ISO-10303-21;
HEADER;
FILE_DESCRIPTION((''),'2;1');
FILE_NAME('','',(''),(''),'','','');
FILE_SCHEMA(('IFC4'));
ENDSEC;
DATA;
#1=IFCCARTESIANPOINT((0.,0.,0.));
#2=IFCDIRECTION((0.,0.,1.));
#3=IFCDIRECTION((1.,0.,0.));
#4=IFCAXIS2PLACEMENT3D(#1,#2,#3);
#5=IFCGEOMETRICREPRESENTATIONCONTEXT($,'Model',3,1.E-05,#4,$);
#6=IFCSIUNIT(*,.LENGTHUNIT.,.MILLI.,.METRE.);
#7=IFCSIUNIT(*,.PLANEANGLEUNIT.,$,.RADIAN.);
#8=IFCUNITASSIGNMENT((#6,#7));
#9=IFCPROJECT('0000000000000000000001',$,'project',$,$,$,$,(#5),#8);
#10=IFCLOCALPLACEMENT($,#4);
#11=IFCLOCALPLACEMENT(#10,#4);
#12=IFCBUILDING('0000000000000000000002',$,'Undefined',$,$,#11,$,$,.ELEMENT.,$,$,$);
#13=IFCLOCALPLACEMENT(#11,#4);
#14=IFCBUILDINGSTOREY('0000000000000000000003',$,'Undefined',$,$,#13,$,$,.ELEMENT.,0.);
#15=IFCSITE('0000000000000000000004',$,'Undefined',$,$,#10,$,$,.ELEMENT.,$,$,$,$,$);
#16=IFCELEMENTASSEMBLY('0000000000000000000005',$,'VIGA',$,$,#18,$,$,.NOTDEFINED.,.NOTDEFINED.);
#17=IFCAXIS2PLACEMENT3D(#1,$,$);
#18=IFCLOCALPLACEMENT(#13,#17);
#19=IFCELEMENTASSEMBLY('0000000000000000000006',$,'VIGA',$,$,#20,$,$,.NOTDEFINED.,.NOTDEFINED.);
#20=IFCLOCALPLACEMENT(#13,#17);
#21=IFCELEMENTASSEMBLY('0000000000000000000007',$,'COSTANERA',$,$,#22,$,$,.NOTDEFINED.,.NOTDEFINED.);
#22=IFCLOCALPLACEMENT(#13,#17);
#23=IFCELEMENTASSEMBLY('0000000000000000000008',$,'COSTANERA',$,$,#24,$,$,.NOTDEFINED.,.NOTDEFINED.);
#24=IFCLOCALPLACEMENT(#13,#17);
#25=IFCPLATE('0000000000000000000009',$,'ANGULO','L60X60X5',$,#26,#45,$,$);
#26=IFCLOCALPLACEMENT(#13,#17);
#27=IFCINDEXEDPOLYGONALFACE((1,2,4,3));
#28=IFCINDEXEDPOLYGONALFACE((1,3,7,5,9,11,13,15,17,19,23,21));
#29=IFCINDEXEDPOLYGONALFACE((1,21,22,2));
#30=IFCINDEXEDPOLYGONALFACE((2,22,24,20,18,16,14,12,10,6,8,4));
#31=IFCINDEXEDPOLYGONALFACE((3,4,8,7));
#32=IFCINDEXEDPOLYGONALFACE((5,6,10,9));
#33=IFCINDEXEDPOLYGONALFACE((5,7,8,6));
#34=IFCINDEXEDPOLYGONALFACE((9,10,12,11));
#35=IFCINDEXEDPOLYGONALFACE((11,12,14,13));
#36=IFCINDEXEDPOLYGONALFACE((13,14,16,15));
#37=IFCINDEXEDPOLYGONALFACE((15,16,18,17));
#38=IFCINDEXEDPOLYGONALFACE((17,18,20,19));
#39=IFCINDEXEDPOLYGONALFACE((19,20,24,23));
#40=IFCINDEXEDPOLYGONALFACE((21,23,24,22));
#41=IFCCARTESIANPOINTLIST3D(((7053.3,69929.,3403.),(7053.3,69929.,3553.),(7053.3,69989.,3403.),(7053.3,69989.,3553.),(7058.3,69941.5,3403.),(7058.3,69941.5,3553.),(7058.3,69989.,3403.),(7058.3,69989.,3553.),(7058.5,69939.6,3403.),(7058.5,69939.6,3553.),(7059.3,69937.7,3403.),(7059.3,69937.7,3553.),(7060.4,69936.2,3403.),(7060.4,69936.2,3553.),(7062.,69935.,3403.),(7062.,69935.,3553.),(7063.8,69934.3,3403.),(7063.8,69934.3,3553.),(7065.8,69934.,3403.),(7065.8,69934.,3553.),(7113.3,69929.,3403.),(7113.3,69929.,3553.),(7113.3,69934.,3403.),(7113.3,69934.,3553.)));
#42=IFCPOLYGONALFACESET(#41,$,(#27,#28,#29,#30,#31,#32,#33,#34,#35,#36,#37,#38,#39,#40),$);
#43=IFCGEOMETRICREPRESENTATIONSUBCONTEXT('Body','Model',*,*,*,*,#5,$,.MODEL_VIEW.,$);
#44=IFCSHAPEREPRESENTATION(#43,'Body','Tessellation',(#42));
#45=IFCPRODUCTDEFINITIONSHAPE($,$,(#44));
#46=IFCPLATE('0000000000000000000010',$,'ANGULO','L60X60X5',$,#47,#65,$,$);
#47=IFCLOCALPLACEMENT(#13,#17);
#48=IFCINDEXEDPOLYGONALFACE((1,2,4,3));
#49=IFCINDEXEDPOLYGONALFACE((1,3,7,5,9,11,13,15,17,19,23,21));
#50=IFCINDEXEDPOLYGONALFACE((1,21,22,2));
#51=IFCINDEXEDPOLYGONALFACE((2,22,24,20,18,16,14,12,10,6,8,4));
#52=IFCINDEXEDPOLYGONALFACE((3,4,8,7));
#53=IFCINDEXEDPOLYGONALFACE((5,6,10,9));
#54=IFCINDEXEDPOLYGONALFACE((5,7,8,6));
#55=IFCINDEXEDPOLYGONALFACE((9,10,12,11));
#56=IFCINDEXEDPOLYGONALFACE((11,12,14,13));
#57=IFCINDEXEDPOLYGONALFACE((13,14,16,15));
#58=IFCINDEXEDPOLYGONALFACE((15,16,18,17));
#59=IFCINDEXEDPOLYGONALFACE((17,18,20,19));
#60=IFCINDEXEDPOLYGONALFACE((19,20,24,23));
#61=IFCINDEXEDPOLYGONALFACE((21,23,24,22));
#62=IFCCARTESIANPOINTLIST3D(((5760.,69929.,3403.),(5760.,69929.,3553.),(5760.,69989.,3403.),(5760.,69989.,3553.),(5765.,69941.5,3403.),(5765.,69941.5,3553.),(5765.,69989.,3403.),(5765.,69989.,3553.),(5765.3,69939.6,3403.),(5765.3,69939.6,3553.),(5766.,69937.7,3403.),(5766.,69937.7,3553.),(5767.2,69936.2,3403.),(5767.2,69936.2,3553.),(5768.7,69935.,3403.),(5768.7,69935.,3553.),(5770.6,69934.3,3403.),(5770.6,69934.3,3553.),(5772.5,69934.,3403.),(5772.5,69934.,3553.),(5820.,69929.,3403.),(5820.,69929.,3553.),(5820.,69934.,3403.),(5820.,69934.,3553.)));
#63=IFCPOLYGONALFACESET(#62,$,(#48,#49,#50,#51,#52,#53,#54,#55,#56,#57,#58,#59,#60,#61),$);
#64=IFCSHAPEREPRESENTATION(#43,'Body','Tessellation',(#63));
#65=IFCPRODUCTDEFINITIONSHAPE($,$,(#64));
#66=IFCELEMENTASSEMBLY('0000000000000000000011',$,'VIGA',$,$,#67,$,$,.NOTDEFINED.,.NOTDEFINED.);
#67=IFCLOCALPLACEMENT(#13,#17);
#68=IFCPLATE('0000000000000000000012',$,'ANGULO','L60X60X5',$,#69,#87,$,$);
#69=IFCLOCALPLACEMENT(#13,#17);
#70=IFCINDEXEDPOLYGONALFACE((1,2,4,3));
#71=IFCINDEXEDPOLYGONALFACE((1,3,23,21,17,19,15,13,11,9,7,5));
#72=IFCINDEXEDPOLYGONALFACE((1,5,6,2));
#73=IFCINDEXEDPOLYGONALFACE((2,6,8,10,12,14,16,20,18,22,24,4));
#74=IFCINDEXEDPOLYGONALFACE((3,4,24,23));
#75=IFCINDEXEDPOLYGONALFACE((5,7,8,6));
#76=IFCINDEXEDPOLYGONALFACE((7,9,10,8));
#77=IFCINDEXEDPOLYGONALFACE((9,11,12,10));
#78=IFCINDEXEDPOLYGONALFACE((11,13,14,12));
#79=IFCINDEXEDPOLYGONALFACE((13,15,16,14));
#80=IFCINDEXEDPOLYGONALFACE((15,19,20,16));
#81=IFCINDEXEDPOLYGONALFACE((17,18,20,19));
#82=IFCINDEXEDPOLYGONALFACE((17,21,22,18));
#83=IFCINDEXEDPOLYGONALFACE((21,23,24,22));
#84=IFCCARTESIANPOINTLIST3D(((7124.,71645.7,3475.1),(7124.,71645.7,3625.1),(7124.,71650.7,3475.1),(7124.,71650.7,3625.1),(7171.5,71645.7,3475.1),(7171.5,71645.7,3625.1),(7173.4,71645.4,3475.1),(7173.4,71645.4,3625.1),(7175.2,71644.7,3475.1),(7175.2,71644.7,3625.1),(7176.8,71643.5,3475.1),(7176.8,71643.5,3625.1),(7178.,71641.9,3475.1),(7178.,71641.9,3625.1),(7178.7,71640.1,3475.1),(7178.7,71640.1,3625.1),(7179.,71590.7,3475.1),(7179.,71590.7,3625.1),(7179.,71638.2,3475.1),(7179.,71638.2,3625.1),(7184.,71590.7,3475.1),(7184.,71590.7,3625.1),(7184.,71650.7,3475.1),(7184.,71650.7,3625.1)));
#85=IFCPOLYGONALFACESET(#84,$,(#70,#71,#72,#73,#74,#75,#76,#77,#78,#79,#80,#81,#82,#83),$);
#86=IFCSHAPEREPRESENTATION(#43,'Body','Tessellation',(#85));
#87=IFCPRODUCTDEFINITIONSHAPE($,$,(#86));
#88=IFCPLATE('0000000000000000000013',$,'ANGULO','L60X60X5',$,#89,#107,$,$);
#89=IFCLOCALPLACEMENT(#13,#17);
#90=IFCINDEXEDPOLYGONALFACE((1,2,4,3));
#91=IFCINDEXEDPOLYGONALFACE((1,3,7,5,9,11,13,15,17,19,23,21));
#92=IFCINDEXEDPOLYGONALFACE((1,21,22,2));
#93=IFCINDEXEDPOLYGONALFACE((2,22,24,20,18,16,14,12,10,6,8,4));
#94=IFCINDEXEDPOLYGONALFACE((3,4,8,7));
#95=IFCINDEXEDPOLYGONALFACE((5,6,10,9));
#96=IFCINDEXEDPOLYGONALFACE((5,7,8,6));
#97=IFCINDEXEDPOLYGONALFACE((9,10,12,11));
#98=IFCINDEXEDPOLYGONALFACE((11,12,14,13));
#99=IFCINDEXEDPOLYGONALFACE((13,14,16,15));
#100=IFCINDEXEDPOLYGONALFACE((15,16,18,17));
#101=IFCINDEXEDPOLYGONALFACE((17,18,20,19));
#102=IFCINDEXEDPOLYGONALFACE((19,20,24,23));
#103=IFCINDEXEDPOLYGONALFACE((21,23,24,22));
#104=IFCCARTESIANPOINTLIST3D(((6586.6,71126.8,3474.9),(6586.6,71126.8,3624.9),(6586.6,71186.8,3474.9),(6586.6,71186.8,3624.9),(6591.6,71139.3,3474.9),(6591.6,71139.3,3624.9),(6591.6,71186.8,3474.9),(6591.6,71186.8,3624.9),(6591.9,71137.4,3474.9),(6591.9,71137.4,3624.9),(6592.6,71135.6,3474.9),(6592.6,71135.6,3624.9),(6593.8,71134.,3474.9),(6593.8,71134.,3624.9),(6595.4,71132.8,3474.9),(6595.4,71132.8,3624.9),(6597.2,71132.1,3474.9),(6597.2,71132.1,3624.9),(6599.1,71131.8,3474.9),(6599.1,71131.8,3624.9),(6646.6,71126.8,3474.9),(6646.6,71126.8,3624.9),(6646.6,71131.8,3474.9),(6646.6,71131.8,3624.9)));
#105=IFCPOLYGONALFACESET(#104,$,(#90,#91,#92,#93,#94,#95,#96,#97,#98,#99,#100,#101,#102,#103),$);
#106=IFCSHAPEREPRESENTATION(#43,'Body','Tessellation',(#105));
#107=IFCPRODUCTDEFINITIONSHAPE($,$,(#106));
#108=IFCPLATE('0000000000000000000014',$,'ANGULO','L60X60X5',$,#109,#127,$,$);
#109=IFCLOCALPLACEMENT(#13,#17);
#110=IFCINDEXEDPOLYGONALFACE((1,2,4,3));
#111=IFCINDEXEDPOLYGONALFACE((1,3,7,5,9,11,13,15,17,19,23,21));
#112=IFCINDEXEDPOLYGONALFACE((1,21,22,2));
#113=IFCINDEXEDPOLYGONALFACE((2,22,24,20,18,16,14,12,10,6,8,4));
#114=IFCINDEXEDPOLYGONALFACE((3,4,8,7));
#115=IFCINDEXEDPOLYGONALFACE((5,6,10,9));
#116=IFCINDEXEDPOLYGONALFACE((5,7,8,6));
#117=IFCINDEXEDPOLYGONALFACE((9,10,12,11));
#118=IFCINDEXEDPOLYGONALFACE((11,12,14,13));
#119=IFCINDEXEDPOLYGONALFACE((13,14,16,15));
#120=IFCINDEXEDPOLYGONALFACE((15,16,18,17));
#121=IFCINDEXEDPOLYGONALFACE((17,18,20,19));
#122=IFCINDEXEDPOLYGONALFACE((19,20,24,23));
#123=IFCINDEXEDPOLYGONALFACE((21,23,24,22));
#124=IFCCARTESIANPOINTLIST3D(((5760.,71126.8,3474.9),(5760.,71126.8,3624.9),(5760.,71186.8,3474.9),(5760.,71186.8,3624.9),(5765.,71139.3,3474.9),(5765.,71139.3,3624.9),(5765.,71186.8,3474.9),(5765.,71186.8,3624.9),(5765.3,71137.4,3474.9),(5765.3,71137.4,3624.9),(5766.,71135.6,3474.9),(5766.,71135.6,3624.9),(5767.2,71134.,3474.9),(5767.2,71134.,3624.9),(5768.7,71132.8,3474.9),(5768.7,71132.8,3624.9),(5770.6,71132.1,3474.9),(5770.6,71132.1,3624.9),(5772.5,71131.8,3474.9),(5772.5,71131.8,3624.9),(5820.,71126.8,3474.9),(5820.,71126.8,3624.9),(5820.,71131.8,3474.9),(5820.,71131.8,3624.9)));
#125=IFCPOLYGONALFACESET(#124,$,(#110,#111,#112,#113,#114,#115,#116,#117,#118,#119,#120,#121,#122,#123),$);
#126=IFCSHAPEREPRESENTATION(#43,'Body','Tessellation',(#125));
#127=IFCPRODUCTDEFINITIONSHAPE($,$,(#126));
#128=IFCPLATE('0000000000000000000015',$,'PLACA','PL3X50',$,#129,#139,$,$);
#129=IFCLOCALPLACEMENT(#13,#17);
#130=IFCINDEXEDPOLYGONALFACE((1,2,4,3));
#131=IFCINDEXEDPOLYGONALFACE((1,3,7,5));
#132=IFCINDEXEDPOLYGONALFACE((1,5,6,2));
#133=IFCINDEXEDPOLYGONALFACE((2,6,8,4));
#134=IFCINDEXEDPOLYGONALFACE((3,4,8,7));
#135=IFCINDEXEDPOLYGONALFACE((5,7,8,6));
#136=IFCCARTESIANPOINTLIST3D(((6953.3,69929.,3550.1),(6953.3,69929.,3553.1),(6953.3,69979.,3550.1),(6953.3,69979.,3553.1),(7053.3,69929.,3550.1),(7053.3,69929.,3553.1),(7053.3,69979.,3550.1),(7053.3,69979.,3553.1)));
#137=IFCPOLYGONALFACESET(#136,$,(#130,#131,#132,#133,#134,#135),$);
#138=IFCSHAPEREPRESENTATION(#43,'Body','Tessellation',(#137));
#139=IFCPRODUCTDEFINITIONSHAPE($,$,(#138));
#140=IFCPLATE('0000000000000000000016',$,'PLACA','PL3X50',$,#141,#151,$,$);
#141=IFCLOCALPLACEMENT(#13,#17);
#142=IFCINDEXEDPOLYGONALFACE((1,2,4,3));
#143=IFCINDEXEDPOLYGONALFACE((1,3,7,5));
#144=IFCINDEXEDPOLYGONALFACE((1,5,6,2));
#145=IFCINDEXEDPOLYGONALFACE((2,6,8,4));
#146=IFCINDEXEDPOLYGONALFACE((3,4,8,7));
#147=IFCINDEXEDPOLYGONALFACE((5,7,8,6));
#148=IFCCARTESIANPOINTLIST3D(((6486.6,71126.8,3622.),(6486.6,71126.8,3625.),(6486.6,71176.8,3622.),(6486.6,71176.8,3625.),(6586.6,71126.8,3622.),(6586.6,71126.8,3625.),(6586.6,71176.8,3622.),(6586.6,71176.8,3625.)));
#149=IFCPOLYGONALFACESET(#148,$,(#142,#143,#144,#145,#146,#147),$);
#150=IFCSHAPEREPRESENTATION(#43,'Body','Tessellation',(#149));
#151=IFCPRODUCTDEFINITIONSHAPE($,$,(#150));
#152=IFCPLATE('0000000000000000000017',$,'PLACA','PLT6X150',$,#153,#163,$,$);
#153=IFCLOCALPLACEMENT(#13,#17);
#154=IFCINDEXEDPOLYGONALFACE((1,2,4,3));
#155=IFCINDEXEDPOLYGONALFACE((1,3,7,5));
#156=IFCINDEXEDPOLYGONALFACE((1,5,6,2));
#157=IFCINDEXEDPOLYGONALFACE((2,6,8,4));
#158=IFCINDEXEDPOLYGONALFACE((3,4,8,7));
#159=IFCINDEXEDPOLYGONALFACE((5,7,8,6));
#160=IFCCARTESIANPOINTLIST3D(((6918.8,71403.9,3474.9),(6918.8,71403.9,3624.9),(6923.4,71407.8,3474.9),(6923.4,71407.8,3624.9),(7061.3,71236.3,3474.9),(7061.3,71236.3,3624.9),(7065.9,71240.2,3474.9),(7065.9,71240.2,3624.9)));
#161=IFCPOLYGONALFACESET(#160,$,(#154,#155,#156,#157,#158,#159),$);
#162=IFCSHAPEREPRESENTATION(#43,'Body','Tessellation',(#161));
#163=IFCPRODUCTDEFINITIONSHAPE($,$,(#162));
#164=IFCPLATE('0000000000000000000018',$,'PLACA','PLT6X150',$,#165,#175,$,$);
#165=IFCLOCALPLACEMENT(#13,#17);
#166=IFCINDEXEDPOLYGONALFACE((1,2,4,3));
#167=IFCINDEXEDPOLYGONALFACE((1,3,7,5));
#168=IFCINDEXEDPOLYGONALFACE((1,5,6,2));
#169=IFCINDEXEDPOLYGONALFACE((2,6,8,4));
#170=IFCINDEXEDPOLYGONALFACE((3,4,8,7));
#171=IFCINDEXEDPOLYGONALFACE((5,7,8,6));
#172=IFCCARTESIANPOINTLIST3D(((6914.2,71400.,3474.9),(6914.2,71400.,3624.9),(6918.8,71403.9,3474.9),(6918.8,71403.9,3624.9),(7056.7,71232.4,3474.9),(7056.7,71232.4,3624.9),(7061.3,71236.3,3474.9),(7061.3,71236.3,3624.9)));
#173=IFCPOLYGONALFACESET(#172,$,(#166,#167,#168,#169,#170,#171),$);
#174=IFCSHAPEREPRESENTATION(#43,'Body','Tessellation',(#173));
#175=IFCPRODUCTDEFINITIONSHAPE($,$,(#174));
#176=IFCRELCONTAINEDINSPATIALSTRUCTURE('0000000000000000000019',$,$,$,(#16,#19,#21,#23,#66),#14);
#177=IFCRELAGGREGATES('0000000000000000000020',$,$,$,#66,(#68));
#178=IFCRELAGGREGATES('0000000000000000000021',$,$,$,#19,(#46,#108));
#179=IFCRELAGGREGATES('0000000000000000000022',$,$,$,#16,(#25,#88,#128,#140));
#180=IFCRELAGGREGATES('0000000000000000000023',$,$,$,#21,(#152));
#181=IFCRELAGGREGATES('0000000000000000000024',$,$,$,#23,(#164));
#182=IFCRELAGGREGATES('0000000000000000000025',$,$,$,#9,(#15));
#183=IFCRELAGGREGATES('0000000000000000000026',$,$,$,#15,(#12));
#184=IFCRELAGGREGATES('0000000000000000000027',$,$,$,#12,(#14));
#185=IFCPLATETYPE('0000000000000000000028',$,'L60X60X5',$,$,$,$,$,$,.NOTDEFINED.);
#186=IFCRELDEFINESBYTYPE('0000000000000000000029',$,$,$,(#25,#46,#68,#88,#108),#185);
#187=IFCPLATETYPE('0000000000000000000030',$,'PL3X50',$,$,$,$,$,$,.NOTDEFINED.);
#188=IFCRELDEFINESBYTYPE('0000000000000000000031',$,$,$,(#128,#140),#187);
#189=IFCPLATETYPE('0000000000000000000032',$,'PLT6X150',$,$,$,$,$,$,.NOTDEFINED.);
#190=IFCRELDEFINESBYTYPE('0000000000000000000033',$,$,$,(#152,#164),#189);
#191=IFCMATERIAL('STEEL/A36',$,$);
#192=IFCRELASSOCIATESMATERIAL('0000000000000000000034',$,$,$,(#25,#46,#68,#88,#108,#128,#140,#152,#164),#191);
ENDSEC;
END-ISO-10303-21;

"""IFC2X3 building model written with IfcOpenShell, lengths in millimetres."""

from ifc_helpers import new_model, si_unit, frame, origin_with_axes, origin_2d_with_axis, place, context, subcontext, project, spatial, polyline, l_section, outline, extrude, material, type_object, element, aggregate, save


model = new_model("IFC2X3")

# Units and contexts
model_context = context("Model", 3, precision=1e-05, world=origin_with_axes())
body_context = subcontext(model_context, "Body", "Model", "MODEL_VIEW")
ifc_project = project(units=[si_unit("LENGTHUNIT", "METRE", prefix="MILLI"), si_unit("PLANEANGLEUNIT", "RADIAN")], contexts=[model_context])

# Site, building, storey
site_placement = place(None, origin_with_axes())
site = spatial("IfcSite", under=ifc_project, at=site_placement, Name="Undefined", CompositionType="ELEMENT")
building_placement = place(site_placement, origin_with_axes())
building = spatial("IfcBuilding", under=site, at=building_placement, Name="Undefined", CompositionType="ELEMENT")
storey_placement = place(building_placement, origin_with_axes())
storey = spatial("IfcBuildingStorey", under=building, at=storey_placement, Name="Undefined", CompositionType="ELEMENT", Elevation=0.0)

# Element assemblies
assembly_1_placement = place(storey_placement, origin_with_axes())
assembly_1 = element("IfcElementAssembly", 1, at=assembly_1_placement, inside=storey, Name="VIGA", AssemblyPlace="NOTDEFINED", PredefinedType="NOTDEFINED")
ifc_material_1 = material(Name="STEEL/A36")
assembly_2_placement = place(storey_placement, origin_with_axes())
assembly_2 = element("IfcElementAssembly", 2, at=assembly_2_placement, inside=storey, Name="VIGA", AssemblyPlace="NOTDEFINED", PredefinedType="NOTDEFINED")

# Element assemblies
assembly_3_placement = place(storey_placement, origin_with_axes())
assembly_3 = element("IfcElementAssembly", 3, at=assembly_3_placement, inside=storey, Name="COSTANERA", AssemblyPlace="NOTDEFINED", PredefinedType="NOTDEFINED")
assembly_4_placement = place(storey_placement, origin_with_axes())
assembly_4 = element("IfcElementAssembly", 4, at=assembly_4_placement, inside=storey, Name="COSTANERA", AssemblyPlace="NOTDEFINED", PredefinedType="NOTDEFINED")

# Plates
plate_type_1 = type_object("IfcPlateType", Name="L60X60X5", PredefinedType="NOTDEFINED")
plate_1_placement = place(assembly_1_placement, frame((7083.3, 69959.0, 3553.0), z_axis=(0.0, 1.0, 0.0), x_axis=(0.0, 0.0, -1.0)))
plate_1 = element("IfcPlate", 5, at=plate_1_placement, type_object=plate_type_1, material=ifc_material_1, Name="ANGULO", Description="L60X60X5", context=body_context, shape_type="SweptSolid", body=[
    extrude(l_section(Depth=60.0, Width=60.0, Thickness=5.0, FilletRadius=7.5, at=origin_2d_with_axis()), frame((150.0, 0.0, 0.0), z_axis=(-1.0, 0.0, 0.0), x_axis=(0.0, -1.0, 0.0)), (0.0, 0.0, 1.0), 150.0),
])
plate_2_placement = place(assembly_2_placement, frame((5790.0, 69959.0, 3553.0), z_axis=(0.0, 1.0, 0.0), x_axis=(0.0, 0.0, -1.0)))
plate_2 = element("IfcPlate", 6, at=plate_2_placement, type_object=plate_type_1, material=ifc_material_1, Name="ANGULO", Description="L60X60X5", context=body_context, shape_type="SweptSolid", body=[
    extrude(l_section(Depth=60.0, Width=60.0, Thickness=5.0, FilletRadius=7.5, at=origin_2d_with_axis()), frame((150.0, 0.0, 0.0), z_axis=(-1.0, 0.0, 0.0), x_axis=(0.0, -1.0, 0.0)), (0.0, 0.0, 1.0), 150.0),
])

# Element assembly, plate
assembly_5_placement = place(storey_placement, origin_with_axes())
assembly_5 = element("IfcElementAssembly", 7, at=assembly_5_placement, inside=storey, Name="VIGA", AssemblyPlace="NOTDEFINED", PredefinedType="NOTDEFINED")
plate_3_placement = place(assembly_5_placement, frame((7154.0, 71620.7, 3475.1), z_axis=(-1.0, 0.0, 0.0), x_axis=(0.0, 0.0, 1.0)))
plate_3 = element("IfcPlate", 8, at=plate_3_placement, type_object=plate_type_1, material=ifc_material_1, Name="ANGULO", Description="L60X60X5", context=body_context, shape_type="SweptSolid", body=[
    extrude(l_section(Depth=60.0, Width=60.0, Thickness=5.0, FilletRadius=7.5, at=origin_2d_with_axis()), frame((150.0, 0.0, 0.0), z_axis=(-1.0, 0.0, 0.0), x_axis=(0.0, -1.0, 0.0)), (0.0, 0.0, 1.0), 150.0),
])
aggregate(assembly_5, [plate_3])

# Plates
plate_4_placement = place(assembly_1_placement, frame((6616.6, 71156.8, 3624.9), z_axis=(0.0, 1.0, 0.0), x_axis=(0.0, 0.0, -1.0)))
plate_4 = element("IfcPlate", 9, at=plate_4_placement, type_object=plate_type_1, material=ifc_material_1, Name="ANGULO", Description="L60X60X5", context=body_context, shape_type="SweptSolid", body=[
    extrude(l_section(Depth=60.0, Width=60.0, Thickness=5.0, FilletRadius=7.5, at=origin_2d_with_axis()), frame((150.0, 0.0, 0.0), z_axis=(-1.0, 0.0, 0.0), x_axis=(0.0, -1.0, 0.0)), (0.0, 0.0, 1.0), 150.0),
])
plate_5_placement = place(assembly_2_placement, frame((5790.0, 71156.8, 3624.9), z_axis=(0.0, 1.0, 0.0), x_axis=(0.0, 0.0, -1.0)))
plate_5 = element("IfcPlate", 10, at=plate_5_placement, type_object=plate_type_1, material=ifc_material_1, Name="ANGULO", Description="L60X60X5", context=body_context, shape_type="SweptSolid", body=[
    extrude(l_section(Depth=60.0, Width=60.0, Thickness=5.0, FilletRadius=7.5, at=origin_2d_with_axis()), frame((150.0, 0.0, 0.0), z_axis=(-1.0, 0.0, 0.0), x_axis=(0.0, -1.0, 0.0)), (0.0, 0.0, 1.0), 150.0),
])
aggregate(assembly_2, [plate_2, plate_5])
plate_type_2 = type_object("IfcPlateType", Name="PL3X50", PredefinedType="NOTDEFINED")
plate_6_placement = place(assembly_1_placement, frame((6953.3, 69929.0, 3551.6), z_axis=(0.0, 0.0, -1.0), x_axis=(0.0, 1.0, 0.0)))
plate_6 = element("IfcPlate", 11, at=plate_6_placement, type_object=plate_type_2, material=ifc_material_1, Name="PLACA", Description="PL3X50", context=body_context, shape_type="SweptSolid", body=[
    extrude(outline(polyline([(0.0, 0.0), (50.0, 0.0), (50.0, 100.0), (0.0, 100.0), (0.0, 0.0)])), frame((0.0, 0.0, -1.5), z_axis=(0.0, 0.0, 1.0), x_axis=(1.0, 0.0, 0.0)), (0.0, 0.0, 1.0), 3.0),
])
plate_7_placement = place(assembly_1_placement, frame((6486.6, 71126.8, 3623.5), z_axis=(0.0, 0.0, -1.0), x_axis=(0.0, 1.0, 0.0)))
plate_7 = element("IfcPlate", 12, at=plate_7_placement, type_object=plate_type_2, material=ifc_material_1, Name="PLACA", Description="PL3X50", context=body_context, shape_type="SweptSolid", body=[
    extrude(outline(polyline([(0.0, 0.0), (50.0, 0.0), (50.0, 100.0), (0.0, 100.0), (0.0, 0.0)])), frame((0.0, 0.0, -1.5), z_axis=(0.0, 0.0, 1.0), x_axis=(1.0, 0.0, 0.0)), (0.0, 0.0, 1.0), 3.0),
])
aggregate(assembly_1, [plate_1, plate_4, plate_6, plate_7])
plate_type_3 = type_object("IfcPlateType", Name="PLT6X150", PredefinedType="NOTDEFINED")
plate_8_placement = place(assembly_3_placement, frame((6921.1, 71405.8, 3624.9), z_axis=(0.761761, 0.647858, 0.0), x_axis=(0.647858, -0.761761, 0.0)))
plate_8 = element("IfcPlate", 13, at=plate_8_placement, type_object=plate_type_3, material=ifc_material_1, Name="PLACA", Description="PLT6X150", context=body_context, shape_type="SweptSolid", body=[
    extrude(outline(polyline([(0.0, 0.0), (220.0, 0.0), (220.0, 150.0), (0.0, 150.0), (0.0, 0.0)])), frame((0.0, 0.0, -3.0), z_axis=(0.0, 0.0, 1.0), x_axis=(1.0, 0.0, 0.0)), (0.0, 0.0, 1.0), 6.0),
])
aggregate(assembly_3, [plate_8])
plate_9_placement = place(assembly_4_placement, frame((6916.5, 71402.0, 3624.9), z_axis=(0.761761, 0.647858, 0.0), x_axis=(0.647858, -0.761761, 0.0)))
plate_9 = element("IfcPlate", 14, at=plate_9_placement, type_object=plate_type_3, material=ifc_material_1, Name="PLACA", Description="PLT6X150", context=body_context, shape_type="SweptSolid", body=[
    extrude(outline(polyline([(0.0, 0.0), (220.0, 0.0), (220.0, 150.0), (0.0, 150.0), (0.0, 0.0)])), frame((0.0, 0.0, -3.0), z_axis=(0.0, 0.0, 1.0), x_axis=(1.0, 0.0, 0.0)), (0.0, 0.0, 1.0), 6.0),
])

aggregate(assembly_4, [plate_9])

save(model, "model.ifc")
